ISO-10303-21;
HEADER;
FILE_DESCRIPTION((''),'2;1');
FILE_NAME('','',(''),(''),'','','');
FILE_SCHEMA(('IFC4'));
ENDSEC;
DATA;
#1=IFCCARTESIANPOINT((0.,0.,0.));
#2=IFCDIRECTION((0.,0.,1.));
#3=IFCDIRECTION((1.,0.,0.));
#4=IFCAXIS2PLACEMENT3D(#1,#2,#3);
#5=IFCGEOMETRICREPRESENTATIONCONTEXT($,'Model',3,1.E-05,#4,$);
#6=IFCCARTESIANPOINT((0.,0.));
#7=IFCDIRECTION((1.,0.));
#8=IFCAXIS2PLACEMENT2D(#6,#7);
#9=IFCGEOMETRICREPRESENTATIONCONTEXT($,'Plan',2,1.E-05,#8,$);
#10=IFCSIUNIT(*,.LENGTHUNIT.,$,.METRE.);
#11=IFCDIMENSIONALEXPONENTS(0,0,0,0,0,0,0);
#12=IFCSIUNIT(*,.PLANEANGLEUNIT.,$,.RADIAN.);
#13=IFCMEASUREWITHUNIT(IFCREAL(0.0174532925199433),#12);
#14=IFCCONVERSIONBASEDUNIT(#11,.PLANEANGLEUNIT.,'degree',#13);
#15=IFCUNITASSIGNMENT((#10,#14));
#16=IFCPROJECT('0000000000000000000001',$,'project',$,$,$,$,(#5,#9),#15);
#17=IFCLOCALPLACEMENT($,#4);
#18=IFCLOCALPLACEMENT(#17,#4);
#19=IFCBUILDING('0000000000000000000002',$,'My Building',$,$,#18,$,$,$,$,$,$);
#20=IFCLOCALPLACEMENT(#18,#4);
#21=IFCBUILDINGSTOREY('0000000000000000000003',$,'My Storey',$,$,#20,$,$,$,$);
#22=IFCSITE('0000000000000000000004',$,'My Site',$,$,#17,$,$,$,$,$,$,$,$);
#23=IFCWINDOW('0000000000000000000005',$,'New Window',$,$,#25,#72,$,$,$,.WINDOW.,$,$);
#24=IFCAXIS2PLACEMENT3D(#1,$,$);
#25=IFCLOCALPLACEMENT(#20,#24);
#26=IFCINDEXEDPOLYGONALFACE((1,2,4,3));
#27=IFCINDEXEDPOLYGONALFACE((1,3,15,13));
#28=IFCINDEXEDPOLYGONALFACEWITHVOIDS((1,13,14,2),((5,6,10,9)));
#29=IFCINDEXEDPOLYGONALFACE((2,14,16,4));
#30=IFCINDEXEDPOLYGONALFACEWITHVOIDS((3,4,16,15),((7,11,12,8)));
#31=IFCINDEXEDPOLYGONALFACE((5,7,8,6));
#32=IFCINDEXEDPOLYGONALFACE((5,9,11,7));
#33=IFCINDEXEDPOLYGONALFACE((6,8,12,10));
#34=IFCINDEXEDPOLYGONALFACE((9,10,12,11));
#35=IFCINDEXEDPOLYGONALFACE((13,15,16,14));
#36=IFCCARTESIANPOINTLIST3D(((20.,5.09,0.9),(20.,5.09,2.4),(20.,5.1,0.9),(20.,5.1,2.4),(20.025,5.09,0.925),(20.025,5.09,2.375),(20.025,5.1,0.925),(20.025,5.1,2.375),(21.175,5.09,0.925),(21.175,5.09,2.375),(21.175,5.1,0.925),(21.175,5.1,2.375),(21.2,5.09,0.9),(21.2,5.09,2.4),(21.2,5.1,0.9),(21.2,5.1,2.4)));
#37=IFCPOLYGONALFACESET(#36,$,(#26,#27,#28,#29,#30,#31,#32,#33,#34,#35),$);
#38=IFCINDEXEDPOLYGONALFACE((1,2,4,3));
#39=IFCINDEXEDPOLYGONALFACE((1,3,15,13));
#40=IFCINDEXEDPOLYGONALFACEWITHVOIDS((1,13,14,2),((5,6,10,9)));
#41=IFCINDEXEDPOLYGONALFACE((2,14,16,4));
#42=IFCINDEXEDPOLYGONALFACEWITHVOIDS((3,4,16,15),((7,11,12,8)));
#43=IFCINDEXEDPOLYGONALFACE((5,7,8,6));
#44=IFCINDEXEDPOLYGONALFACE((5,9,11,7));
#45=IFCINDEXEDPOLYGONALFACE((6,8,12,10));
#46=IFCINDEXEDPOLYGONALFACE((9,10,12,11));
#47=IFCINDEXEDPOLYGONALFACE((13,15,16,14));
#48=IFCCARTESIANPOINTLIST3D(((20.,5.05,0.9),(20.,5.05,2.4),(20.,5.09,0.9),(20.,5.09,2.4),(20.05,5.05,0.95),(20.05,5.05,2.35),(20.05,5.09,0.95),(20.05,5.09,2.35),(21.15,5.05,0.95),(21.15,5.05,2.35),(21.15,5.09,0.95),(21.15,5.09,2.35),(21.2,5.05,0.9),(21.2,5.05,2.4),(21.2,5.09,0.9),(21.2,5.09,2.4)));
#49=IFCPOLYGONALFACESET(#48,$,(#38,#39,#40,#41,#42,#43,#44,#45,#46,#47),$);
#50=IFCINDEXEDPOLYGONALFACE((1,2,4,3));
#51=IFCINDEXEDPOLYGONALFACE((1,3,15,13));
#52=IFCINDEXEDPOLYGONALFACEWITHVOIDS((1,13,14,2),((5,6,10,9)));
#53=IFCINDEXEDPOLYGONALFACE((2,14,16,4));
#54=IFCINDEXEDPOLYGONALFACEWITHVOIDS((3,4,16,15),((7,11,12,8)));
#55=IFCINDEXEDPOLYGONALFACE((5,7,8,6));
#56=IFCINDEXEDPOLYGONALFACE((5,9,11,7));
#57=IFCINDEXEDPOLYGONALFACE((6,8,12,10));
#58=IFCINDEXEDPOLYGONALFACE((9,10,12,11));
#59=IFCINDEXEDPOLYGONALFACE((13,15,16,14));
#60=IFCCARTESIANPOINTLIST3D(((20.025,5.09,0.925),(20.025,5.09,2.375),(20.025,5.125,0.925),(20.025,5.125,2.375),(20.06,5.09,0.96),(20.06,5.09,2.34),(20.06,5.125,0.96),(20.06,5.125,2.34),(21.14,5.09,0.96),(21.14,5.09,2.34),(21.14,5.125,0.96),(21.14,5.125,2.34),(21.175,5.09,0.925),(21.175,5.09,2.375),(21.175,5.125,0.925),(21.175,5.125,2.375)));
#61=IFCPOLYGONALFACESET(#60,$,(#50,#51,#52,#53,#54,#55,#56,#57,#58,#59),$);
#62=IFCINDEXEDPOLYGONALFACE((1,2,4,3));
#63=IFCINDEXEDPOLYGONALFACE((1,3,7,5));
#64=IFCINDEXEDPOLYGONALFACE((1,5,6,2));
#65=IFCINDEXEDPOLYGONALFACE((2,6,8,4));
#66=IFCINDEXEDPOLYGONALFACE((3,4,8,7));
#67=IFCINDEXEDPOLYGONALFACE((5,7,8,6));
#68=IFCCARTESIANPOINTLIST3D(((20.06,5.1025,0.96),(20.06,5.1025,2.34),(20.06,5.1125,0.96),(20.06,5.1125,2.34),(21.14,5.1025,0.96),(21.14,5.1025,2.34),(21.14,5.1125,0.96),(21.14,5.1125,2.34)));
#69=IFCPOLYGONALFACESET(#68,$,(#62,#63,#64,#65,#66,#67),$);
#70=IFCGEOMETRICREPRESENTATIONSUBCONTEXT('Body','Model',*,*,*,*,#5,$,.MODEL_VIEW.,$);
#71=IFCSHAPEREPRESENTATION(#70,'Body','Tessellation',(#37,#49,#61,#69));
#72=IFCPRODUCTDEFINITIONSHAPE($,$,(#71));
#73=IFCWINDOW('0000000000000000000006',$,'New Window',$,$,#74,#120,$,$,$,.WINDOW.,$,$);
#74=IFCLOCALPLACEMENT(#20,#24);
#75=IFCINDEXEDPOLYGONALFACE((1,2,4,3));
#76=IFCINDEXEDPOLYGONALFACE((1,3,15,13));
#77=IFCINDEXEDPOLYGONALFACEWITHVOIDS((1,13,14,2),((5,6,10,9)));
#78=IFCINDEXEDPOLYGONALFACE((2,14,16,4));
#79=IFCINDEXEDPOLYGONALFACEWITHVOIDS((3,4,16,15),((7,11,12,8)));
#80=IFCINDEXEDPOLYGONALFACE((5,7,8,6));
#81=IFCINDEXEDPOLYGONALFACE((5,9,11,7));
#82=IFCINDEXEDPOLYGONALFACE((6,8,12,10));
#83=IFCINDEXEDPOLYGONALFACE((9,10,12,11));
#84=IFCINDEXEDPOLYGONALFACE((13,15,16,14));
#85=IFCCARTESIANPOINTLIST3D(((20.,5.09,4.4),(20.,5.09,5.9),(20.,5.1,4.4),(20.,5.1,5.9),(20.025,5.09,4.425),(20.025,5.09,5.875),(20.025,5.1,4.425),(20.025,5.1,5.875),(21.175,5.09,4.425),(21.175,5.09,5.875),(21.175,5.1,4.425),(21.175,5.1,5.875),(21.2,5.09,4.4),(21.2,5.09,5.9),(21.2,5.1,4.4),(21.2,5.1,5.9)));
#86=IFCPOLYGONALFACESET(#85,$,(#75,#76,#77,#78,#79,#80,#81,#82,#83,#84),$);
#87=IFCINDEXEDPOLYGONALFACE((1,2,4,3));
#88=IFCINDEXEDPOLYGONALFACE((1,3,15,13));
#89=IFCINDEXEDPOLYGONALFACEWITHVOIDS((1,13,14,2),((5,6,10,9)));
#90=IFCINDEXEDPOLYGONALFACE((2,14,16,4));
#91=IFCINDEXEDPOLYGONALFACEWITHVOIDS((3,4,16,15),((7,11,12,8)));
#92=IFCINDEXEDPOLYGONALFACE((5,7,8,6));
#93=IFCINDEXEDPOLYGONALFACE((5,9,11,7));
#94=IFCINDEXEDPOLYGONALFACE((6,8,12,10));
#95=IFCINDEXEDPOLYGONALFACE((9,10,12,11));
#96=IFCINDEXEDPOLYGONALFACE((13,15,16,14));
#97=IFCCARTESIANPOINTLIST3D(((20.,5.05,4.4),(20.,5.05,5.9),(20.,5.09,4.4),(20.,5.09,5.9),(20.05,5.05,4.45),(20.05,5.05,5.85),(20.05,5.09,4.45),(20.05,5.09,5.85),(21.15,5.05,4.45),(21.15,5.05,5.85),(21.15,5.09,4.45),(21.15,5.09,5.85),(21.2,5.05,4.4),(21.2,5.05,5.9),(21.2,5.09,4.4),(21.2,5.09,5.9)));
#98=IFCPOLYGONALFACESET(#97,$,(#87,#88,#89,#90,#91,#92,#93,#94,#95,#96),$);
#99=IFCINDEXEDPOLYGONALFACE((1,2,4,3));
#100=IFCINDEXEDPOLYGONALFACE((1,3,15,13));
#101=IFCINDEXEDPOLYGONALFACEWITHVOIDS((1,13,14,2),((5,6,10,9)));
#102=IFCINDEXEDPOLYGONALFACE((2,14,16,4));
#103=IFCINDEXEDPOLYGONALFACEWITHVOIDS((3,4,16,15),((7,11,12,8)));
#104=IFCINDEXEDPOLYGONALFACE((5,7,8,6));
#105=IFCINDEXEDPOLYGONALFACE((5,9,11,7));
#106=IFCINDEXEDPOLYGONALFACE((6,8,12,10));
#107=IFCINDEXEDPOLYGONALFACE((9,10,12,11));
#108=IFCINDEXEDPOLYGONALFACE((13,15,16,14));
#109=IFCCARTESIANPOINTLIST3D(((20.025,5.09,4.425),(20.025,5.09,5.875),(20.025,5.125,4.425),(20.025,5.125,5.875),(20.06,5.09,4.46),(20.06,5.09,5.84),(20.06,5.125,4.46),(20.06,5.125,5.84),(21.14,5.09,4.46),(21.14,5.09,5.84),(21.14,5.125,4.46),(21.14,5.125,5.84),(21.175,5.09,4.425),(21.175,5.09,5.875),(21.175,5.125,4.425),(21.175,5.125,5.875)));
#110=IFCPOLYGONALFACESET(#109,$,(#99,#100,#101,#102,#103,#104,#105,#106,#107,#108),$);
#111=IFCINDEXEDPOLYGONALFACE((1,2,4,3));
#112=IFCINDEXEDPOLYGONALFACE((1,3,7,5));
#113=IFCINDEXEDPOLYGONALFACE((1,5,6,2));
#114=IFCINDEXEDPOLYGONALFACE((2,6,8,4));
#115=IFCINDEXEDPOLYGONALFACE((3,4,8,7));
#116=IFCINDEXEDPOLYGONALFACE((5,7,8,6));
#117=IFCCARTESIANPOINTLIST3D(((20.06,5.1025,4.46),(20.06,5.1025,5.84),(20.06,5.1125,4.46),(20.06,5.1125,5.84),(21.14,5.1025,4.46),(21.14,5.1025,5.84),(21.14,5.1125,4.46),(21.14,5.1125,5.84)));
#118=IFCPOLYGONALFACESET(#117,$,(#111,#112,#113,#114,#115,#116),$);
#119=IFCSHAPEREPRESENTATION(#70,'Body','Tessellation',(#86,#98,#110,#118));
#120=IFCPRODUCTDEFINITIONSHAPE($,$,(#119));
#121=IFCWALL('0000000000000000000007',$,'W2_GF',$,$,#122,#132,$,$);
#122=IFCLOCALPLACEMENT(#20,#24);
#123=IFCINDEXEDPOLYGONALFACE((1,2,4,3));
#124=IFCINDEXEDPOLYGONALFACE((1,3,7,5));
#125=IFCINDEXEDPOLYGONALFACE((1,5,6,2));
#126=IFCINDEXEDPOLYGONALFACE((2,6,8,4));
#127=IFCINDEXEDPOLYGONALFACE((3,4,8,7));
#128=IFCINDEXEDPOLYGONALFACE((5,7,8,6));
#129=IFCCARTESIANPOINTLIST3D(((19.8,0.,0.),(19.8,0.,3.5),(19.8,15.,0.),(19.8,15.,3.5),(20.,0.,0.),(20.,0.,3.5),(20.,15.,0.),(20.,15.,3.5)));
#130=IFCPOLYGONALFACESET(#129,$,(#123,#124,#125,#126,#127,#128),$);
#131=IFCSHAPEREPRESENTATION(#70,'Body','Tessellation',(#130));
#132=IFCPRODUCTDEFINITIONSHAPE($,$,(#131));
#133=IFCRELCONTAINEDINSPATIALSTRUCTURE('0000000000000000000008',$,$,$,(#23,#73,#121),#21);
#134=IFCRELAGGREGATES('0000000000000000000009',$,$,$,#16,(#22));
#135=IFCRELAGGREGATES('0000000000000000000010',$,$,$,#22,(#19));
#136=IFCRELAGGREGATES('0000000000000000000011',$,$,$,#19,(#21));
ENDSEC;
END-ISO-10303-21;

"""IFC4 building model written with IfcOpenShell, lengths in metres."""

from ifc_helpers import new_model, entity, si_unit, converted_unit, frame, origin_with_axes, origin_2d_with_axis, place, context, subcontext, project, spatial, line, indexed_curve, outline, extrude, element, save


model = new_model("IFC4")

# Units and contexts
model_context = context("Model", 3, precision=1e-05, world=origin_with_axes())
plan_context = context("Plan", 2, precision=1e-05, world=origin_2d_with_axis())
body_context = subcontext(model_context, "Body", "Model", "MODEL_VIEW")
ifc_project = project(units=[si_unit("LENGTHUNIT", "METRE"), converted_unit("PLANEANGLEUNIT", "degree", entity("IfcReal", 0.0174532925199433), si_unit("PLANEANGLEUNIT", "RADIAN"), dimensions=[0, 0, 0, 0, 0, 0, 0])], contexts=[model_context, plan_context])

# Site, building, storey
site_placement = place(None, origin_with_axes())
site = spatial("IfcSite", under=ifc_project, at=site_placement, Name="My Site")
building_placement = place(site_placement, origin_with_axes())
building = spatial("IfcBuilding", under=site, at=building_placement, Name="My Building")
storey_placement = place(building_placement, origin_with_axes())
storey = spatial("IfcBuildingStorey", under=building, at=storey_placement, Name="My Storey")

# Windows
for number, where, z_axis, x_axis, name in (
    (1, (20.0, 5.0, 0.9), (0.0, 0.0, 1.0), (1.0, 0.0, 0.0), "New Window"),
    (2, (20.0, 5.0, 4.4), (0.0, 0.0, 1.0), (1.0, 0.0, 0.0), "New Window"),
):
    element("IfcWindow", number, at=place(storey_placement, frame(where, z_axis=z_axis, x_axis=x_axis)), inside=storey, Name=name, PredefinedType="WINDOW", context=body_context, shape_type="SweptSolid", body=[
        extrude(outline(indexed_curve([(0.0, 0.0), (1.2, 0.0), (1.2, 1.5), (0.0, 1.5)], segments=[line(1, 2, 3, 4, 1)]), holes=[indexed_curve([(0.025, 0.025), (1.175, 0.025), (1.175, 1.475), (0.025, 1.475)], segments=[line(1, 2, 3, 4, 1)])]), frame((0.0, 0.09, 0.0), z_axis=(0.0, -1.0, 0.0), x_axis=(1.0, 0.0, 0.0)), (0.0, 0.0, -1.0), 0.01),
        extrude(outline(indexed_curve([(0.0, 0.0), (1.2, 0.0), (1.2, 1.5), (0.0, 1.5)], segments=[line(1, 2, 3, 4, 1)]), holes=[indexed_curve([(0.05, 0.05), (1.15, 0.05), (1.15, 1.45), (0.05, 1.45)], segments=[line(1, 2, 3, 4, 1)])]), frame((0.0, 0.05, 0.0), z_axis=(0.0, -1.0, 0.0), x_axis=(1.0, 0.0, 0.0)), (0.0, 0.0, -1.0), 0.04),
        extrude(outline(indexed_curve([(0.0, 0.0), (1.15, 0.0), (1.15, 1.45), (0.0, 1.45)], segments=[line(1, 2, 3, 4, 1)]), holes=[indexed_curve([(0.035, 0.035), (1.115, 0.035), (1.115, 1.415), (0.035, 1.415)], segments=[line(1, 2, 3, 4, 1)])]), frame((0.025, 0.09, 0.025), z_axis=(0.0, -1.0, 0.0), x_axis=(1.0, 0.0, 0.0)), (0.0, 0.0, -1.0), 0.035),
        extrude(outline(indexed_curve([(0.035, 0.035), (1.115, 0.035), (1.115, 1.415), (0.035, 1.415)], segments=[line(1, 2, 3, 4, 1)])), frame((0.025, 0.1025, 0.025), z_axis=(0.0, -1.0, 0.0), x_axis=(1.0, 0.0, 0.0)), (0.0, 0.0, -1.0), 0.01),
    ])

# Wall
for number, where, z_axis, x_axis, name in (
    (3, (20.0, 0.0, 0.0), (0.0, 0.0, 1.0), (0.0, 1.0, 0.0), "W2_GF"),
):
    element("IfcWall", number, at=place(storey_placement, frame(where, z_axis=z_axis, x_axis=x_axis)), inside=storey, Name=name, context=body_context, shape_type="SweptSolid", body=[
        extrude(outline(indexed_curve([(0.0, 0.0), (0.0, 0.2), (15.0, 0.2), (15.0, 0.0), (0.0, 0.0)], self_intersect=False)), origin_with_axes(), (0.0, 0.0, 1.0), 3.5),
    ])

save(model, "model.ifc")
